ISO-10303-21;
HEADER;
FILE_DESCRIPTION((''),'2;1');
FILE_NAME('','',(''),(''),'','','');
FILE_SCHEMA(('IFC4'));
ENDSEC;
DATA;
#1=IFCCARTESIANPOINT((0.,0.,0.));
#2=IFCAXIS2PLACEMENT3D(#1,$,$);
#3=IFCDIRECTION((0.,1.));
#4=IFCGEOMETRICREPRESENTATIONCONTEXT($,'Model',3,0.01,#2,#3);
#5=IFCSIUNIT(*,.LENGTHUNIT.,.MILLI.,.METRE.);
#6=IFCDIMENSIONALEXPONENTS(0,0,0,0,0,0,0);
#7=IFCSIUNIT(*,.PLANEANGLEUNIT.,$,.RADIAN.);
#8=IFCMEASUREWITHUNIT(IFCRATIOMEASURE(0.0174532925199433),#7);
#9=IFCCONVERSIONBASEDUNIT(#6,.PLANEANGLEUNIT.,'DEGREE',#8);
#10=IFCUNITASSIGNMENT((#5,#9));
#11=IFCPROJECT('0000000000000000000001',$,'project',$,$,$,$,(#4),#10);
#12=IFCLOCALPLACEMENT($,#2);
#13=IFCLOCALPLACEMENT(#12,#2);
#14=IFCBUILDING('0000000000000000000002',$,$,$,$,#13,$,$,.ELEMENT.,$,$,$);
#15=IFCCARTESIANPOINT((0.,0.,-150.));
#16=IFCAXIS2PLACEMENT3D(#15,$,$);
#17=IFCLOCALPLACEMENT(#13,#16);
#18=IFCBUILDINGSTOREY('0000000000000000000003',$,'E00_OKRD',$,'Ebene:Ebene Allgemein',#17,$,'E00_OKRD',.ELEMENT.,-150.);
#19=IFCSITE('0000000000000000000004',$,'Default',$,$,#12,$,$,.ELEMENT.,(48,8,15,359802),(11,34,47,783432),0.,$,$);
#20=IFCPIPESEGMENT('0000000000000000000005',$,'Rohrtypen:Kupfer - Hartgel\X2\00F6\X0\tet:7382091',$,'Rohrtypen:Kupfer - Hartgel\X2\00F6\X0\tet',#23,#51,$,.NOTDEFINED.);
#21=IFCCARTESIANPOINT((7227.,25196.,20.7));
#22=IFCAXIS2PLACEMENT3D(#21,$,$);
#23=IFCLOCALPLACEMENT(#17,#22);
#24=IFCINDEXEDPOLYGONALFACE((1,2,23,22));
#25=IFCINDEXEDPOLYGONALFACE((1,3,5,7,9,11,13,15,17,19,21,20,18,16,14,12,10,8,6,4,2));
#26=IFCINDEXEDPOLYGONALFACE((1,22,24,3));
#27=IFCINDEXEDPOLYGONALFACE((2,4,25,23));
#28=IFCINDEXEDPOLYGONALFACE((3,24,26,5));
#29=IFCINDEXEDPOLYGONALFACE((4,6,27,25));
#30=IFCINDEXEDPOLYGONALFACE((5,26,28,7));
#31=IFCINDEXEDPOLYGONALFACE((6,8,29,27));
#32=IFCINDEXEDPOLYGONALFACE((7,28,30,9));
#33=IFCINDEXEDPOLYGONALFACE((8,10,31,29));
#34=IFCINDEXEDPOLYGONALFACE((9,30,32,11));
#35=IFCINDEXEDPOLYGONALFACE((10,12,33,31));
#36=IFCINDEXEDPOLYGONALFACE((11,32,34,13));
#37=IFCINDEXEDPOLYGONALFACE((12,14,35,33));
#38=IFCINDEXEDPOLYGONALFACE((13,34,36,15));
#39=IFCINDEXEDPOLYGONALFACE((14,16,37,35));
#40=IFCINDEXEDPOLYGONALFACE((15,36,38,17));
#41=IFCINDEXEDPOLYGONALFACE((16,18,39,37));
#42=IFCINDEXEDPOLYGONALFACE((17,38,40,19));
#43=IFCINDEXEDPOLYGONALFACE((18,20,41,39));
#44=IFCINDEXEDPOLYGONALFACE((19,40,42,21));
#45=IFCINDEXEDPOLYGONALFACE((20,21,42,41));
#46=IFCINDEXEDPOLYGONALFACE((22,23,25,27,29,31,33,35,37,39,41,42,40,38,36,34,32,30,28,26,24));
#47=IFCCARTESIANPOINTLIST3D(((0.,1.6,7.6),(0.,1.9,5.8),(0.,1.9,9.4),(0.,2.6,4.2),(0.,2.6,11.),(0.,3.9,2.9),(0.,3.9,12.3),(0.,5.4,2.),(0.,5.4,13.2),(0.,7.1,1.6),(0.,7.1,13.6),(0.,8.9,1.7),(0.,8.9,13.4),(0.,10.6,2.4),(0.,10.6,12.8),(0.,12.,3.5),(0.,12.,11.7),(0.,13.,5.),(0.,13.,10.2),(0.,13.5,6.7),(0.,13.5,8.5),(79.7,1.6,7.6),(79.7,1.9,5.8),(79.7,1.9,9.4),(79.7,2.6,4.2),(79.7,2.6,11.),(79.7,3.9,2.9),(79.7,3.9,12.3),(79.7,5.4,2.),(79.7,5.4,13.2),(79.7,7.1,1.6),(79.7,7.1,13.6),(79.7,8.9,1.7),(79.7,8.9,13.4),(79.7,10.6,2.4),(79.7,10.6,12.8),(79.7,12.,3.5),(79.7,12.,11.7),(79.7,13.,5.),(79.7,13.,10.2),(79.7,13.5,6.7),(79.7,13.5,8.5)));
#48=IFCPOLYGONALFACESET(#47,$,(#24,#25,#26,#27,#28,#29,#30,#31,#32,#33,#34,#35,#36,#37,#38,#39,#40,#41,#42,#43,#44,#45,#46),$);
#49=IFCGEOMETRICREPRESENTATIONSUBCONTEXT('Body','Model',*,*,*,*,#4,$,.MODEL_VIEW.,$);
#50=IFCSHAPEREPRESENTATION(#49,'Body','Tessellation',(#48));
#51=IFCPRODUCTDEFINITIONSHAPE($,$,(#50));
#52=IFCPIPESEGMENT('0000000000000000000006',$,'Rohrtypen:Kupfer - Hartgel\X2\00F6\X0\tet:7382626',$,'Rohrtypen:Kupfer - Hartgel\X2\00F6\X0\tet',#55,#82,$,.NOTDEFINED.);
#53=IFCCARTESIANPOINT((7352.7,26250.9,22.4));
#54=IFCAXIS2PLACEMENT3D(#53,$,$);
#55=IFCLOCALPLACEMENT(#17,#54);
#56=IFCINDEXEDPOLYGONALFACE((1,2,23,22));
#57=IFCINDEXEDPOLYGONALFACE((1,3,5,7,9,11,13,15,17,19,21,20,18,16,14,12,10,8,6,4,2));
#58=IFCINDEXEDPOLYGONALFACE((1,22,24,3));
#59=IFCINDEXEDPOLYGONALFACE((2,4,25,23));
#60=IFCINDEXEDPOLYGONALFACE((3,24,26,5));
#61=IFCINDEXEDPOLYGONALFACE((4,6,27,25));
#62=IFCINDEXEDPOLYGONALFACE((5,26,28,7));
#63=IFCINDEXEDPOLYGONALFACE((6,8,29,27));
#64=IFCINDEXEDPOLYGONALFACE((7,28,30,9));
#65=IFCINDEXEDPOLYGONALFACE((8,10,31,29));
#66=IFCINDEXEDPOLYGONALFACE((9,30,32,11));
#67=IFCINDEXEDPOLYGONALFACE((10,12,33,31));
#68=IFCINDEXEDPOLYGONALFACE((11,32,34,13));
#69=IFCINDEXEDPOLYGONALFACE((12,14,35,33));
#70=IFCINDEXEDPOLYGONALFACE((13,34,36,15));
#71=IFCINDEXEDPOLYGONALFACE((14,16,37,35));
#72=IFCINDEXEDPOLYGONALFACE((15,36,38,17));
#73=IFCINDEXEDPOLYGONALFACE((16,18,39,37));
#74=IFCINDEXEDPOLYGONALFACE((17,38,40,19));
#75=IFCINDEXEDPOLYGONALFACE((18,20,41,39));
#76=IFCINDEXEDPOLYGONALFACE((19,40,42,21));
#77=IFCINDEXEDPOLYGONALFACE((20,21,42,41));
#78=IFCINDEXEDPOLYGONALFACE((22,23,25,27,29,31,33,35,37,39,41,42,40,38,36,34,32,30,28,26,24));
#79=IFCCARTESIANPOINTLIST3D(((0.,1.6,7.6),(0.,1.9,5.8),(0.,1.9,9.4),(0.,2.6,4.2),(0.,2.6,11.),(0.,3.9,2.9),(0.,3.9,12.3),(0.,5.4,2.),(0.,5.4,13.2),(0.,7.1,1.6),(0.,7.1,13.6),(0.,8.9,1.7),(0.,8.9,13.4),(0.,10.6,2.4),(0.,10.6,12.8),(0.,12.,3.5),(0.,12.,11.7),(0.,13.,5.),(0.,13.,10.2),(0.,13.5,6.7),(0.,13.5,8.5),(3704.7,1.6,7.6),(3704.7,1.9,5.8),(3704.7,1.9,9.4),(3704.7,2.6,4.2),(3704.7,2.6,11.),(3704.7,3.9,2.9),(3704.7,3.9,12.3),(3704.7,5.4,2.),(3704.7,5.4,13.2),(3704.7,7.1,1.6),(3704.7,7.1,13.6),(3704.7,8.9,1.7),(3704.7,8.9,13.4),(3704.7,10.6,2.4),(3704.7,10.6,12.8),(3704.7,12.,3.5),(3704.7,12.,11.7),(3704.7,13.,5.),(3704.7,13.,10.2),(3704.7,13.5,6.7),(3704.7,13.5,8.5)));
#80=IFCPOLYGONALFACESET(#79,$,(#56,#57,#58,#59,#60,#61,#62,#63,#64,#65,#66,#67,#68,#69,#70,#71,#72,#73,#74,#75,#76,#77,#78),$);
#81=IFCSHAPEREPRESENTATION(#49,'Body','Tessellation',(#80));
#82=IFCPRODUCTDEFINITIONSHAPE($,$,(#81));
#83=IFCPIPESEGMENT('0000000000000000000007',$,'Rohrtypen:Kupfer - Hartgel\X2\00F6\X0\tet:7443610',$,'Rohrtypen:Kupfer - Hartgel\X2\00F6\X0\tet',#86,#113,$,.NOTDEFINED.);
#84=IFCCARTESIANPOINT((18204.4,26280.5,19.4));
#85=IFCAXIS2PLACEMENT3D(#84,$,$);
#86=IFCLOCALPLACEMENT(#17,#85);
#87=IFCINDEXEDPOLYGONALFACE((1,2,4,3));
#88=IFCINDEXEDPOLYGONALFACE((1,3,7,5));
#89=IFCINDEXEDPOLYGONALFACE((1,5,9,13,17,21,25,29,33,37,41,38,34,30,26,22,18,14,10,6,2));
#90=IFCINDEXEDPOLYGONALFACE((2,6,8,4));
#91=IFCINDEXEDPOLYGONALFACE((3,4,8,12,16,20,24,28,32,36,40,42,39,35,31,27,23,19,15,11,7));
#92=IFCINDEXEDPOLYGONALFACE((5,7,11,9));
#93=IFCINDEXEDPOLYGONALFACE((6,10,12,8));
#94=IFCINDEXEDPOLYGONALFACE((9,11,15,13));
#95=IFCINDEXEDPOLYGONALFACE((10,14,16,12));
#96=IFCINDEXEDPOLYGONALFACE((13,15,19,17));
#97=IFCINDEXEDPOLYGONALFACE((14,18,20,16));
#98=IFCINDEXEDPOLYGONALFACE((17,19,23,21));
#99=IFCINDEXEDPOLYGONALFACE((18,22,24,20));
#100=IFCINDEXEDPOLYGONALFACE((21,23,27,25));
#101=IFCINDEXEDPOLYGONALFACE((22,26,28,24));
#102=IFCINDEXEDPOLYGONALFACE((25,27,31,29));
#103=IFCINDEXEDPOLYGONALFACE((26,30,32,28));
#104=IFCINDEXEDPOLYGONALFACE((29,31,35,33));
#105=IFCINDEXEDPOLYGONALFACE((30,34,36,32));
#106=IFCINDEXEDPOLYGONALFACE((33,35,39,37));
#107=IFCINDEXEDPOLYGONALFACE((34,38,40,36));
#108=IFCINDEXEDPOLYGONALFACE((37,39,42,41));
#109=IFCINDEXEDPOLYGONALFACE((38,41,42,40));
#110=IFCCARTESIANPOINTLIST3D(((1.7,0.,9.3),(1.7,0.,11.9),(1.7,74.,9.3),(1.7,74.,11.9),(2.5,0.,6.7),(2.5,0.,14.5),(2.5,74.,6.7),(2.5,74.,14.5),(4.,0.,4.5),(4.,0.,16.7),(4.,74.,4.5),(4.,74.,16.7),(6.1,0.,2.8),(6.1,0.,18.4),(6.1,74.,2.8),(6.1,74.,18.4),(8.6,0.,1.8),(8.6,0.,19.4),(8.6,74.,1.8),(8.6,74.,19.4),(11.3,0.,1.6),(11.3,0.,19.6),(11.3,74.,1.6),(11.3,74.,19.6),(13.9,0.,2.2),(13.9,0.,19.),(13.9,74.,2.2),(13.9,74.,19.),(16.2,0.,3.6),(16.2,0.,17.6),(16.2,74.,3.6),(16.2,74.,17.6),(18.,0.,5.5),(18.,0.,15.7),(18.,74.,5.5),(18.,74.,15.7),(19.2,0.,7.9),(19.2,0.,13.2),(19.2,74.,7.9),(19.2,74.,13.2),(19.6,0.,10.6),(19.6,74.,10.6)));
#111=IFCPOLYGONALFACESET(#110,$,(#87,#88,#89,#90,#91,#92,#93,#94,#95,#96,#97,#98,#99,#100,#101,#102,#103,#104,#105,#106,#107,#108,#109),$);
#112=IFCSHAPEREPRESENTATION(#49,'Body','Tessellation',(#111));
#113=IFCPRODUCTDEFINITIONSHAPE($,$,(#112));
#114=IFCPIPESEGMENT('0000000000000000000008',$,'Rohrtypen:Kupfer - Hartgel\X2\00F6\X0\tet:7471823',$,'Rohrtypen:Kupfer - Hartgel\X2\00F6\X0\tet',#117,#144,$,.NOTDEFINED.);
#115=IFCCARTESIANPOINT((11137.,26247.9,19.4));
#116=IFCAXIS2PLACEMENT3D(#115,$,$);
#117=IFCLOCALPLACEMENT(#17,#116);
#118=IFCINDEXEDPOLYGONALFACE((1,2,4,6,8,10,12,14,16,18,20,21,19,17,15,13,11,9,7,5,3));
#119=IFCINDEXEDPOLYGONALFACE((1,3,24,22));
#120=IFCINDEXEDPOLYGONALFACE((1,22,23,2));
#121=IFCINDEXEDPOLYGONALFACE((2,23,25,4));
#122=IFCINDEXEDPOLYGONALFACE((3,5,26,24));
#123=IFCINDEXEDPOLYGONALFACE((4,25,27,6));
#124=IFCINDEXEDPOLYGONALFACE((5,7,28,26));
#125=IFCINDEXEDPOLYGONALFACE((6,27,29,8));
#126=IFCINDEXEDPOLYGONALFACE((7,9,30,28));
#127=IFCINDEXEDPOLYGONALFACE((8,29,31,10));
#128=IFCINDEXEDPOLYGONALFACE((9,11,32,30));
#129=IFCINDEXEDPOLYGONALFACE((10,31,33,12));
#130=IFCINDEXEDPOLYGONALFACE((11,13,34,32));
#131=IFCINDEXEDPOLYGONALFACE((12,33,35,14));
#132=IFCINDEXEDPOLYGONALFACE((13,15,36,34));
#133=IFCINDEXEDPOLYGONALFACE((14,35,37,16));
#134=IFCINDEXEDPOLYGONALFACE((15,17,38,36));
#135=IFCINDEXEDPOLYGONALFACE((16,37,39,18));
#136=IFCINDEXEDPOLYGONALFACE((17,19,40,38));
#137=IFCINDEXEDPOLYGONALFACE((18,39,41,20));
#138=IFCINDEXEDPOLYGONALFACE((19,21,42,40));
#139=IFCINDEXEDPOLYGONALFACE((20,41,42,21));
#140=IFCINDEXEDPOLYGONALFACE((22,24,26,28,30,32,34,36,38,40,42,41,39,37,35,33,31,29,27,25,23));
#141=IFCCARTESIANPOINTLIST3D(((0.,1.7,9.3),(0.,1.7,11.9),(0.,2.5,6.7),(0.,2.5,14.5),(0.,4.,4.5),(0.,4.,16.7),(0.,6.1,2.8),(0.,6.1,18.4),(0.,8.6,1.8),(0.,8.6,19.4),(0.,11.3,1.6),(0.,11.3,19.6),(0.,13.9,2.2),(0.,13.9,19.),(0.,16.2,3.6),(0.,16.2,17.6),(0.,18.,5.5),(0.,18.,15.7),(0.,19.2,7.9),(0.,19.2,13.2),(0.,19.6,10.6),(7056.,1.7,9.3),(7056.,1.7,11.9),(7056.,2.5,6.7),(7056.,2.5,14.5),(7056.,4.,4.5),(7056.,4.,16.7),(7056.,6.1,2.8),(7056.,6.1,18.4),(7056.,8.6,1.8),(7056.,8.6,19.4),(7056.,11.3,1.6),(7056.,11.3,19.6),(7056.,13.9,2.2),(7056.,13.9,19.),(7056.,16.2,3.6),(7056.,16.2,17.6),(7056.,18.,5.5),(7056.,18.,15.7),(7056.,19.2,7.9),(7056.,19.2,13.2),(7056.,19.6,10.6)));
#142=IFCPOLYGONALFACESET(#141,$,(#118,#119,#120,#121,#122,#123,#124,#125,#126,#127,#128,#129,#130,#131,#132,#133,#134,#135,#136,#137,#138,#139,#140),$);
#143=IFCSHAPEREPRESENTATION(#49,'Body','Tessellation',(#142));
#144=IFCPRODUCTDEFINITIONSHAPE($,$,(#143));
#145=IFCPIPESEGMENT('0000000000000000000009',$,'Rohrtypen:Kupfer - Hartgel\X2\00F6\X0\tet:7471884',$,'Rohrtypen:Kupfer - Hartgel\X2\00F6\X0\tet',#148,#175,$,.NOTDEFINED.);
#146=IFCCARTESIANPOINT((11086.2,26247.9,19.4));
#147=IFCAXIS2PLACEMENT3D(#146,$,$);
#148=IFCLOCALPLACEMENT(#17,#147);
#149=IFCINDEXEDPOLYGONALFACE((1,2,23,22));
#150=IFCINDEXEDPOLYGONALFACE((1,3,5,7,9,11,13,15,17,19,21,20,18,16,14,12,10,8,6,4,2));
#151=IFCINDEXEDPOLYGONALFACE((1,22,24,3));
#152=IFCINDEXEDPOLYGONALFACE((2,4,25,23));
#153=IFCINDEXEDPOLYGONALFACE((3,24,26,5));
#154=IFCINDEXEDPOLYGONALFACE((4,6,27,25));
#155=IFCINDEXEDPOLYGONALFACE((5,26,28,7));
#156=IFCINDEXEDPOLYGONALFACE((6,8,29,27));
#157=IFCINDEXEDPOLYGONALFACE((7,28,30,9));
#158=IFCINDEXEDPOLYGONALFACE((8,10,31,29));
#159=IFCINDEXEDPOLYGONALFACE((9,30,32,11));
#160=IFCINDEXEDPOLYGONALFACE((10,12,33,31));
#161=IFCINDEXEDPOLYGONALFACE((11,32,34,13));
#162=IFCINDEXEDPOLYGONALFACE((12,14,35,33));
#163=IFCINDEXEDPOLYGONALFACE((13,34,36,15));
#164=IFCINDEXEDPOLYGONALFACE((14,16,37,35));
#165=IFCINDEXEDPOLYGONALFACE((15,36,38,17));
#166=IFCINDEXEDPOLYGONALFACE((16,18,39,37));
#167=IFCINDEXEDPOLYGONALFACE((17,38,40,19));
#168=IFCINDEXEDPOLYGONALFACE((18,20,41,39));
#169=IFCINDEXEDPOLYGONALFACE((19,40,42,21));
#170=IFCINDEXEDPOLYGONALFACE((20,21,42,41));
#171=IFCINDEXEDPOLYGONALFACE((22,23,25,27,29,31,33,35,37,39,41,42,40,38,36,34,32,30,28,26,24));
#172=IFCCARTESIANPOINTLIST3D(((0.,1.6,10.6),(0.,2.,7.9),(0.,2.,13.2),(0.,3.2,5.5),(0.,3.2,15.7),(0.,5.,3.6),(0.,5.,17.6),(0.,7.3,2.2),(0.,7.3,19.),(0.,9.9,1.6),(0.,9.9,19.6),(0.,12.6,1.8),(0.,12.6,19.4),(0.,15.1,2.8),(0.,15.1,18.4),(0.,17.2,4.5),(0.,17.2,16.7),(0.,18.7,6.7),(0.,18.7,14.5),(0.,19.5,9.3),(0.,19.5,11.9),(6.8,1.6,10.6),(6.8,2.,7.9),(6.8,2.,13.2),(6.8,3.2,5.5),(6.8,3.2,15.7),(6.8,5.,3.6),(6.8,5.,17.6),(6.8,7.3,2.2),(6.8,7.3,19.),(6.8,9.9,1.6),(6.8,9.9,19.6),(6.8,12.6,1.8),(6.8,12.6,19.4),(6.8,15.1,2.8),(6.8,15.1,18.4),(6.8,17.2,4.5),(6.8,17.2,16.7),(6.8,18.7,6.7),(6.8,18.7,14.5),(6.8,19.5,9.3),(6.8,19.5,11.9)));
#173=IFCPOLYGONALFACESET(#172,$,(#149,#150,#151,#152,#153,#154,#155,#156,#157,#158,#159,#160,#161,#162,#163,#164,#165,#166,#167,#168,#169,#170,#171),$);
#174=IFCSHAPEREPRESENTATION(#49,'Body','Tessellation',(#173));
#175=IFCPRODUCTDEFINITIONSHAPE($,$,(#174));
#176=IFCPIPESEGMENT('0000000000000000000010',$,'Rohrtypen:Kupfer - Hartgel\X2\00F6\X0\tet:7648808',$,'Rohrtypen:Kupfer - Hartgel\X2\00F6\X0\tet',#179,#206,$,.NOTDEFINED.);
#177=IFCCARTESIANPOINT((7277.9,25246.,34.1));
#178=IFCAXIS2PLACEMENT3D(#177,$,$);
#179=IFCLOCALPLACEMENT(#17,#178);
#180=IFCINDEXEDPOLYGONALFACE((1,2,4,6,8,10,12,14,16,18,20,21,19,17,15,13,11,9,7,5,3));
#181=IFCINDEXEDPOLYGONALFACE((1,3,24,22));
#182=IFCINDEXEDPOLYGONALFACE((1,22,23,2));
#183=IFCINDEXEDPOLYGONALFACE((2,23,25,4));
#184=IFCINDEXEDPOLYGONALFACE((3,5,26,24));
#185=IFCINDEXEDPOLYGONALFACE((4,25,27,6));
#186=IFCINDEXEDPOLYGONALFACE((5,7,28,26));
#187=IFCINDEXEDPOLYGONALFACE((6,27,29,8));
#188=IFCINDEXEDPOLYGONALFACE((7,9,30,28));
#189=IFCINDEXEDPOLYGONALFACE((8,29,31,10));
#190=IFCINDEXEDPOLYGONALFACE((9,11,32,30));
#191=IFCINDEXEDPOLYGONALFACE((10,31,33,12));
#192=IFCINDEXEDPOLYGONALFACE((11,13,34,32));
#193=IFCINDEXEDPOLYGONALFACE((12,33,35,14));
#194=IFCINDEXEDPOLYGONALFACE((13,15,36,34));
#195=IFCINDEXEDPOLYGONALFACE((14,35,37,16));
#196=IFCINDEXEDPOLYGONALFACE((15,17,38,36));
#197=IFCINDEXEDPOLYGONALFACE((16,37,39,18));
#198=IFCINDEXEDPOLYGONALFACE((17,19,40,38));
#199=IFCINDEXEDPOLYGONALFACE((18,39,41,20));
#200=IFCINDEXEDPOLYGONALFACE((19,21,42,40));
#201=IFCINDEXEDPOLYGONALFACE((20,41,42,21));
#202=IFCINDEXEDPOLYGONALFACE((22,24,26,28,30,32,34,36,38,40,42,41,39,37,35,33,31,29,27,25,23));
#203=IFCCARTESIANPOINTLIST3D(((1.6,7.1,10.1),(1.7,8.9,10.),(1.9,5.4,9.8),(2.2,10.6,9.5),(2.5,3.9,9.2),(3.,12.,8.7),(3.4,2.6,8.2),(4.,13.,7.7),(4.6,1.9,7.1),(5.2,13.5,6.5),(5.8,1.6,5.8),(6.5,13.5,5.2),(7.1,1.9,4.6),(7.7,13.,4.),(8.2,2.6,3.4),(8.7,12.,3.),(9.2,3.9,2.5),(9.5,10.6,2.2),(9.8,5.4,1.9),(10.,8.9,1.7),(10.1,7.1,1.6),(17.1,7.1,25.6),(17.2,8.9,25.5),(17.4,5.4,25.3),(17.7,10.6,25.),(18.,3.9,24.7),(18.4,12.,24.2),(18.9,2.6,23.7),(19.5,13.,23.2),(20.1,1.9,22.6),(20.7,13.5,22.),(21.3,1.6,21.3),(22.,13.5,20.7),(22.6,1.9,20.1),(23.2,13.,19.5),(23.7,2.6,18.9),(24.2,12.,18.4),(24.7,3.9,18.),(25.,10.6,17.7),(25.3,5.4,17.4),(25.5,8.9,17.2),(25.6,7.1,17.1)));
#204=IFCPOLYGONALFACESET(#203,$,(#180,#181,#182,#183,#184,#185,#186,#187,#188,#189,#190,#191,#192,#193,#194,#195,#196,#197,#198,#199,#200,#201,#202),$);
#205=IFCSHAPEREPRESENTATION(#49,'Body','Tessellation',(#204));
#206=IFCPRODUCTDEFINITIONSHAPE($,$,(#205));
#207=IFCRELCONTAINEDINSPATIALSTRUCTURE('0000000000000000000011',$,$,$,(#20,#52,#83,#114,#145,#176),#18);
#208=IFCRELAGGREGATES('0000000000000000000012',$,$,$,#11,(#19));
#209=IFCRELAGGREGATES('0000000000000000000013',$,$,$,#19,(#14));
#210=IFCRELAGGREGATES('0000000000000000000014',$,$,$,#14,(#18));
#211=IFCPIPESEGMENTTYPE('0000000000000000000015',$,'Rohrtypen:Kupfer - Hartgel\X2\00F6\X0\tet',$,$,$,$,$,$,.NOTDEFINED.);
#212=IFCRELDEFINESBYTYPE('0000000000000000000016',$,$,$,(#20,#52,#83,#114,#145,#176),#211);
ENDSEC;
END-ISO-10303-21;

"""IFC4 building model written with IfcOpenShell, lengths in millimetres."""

from ifc_helpers import new_model, entity, si_unit, converted_unit, direction, frame, frame_2d, origin, origin_2d_with_axis, place, context, subcontext, project, spatial, circle, extrude, type_object, element, save


model = new_model("IFC4")

# Units and contexts
model_context = context("Model", 3, precision=0.01, world=origin(), true_north=direction((0.0, 1.0)))
body_context = subcontext(model_context, "Body", "Model", "MODEL_VIEW")
ifc_project = project(units=[si_unit("LENGTHUNIT", "METRE", prefix="MILLI"), converted_unit("PLANEANGLEUNIT", "DEGREE", entity("IfcRatioMeasure", 0.0174532925199433), si_unit("PLANEANGLEUNIT", "RADIAN"), dimensions=[0, 0, 0, 0, 0, 0, 0])], contexts=[model_context])

# Site, building, storey
site_placement = place(None, origin())
site = spatial("IfcSite", under=ifc_project, at=site_placement, Name="Default", CompositionType="ELEMENT", RefLatitude=(48, 8, 15, 359802), RefLongitude=(11, 34, 47, 783432), RefElevation=0.0)
building_placement = place(site_placement, origin())
building = spatial("IfcBuilding", under=site, at=building_placement, CompositionType="ELEMENT")
storey_placement = place(building_placement, frame((0.0, 0.0, -150.0)))
storey = spatial("IfcBuildingStorey", under=building, at=storey_placement, Name="E00_OKRD", ObjectType="Ebene:Ebene Allgemein", LongName="E00_OKRD", CompositionType="ELEMENT", Elevation=-150.0)

# Pipe segments
pipe_segment_type = type_object("IfcPipeSegmentType", Name="Rohrtypen:Kupfer - Hartgelötet", PredefinedType="NOTDEFINED")
pipe_segment_1_placement = place(storey_placement, frame((7227.0, 25196.0, 20.7)))
element("IfcPipeSegment", 1, at=pipe_segment_1_placement, inside=storey, type_object=pipe_segment_type, Name="Rohrtypen:Kupfer - Hartgelötet:7382091", ObjectType="Rohrtypen:Kupfer - Hartgelötet", PredefinedType="NOTDEFINED", context=body_context, shape_type="SweptSolid", body=[
    extrude(circle(Radius=6.0, at=frame_2d((0.0, 0.0), x_axis=(1.0, 0.0))), frame((0.0, 7.6, 7.6), z_axis=(1.0, 0.0, 0.0), x_axis=(0.0, -1.0, 0.0)), (0.0, 0.0, 1.0), 79.7),
])
pipe_segment_2_placement = place(storey_placement, frame((7352.7, 26250.9, 22.4)))
element("IfcPipeSegment", 2, at=pipe_segment_2_placement, inside=storey, type_object=pipe_segment_type, Name="Rohrtypen:Kupfer - Hartgelötet:7382626", ObjectType="Rohrtypen:Kupfer - Hartgelötet", PredefinedType="NOTDEFINED", context=body_context, shape_type="SweptSolid", body=[
    extrude(circle(Radius=6.0, at=frame_2d((0.0, 0.0), x_axis=(1.0, 0.0))), frame((0.0, 7.6, 7.6), z_axis=(1.0, 0.0, 0.0), x_axis=(0.0, -1.0, 0.0)), (0.0, 0.0, 1.0), 3704.7),
])
pipe_segment_3_placement = place(storey_placement, frame((18204.4, 26280.5, 19.4)))
element("IfcPipeSegment", 3, at=pipe_segment_3_placement, inside=storey, type_object=pipe_segment_type, Name="Rohrtypen:Kupfer - Hartgelötet:7443610", ObjectType="Rohrtypen:Kupfer - Hartgelötet", PredefinedType="NOTDEFINED", context=body_context, shape_type="SweptSolid", body=[
    extrude(circle(Radius=9.0, at=origin_2d_with_axis()), frame((10.6, 0.0, 10.6), z_axis=(0.0, 1.0, 0.0), x_axis=(1.0, 0.0, 0.0)), (0.0, 0.0, 1.0), 74.0),
])
pipe_segment_4_placement = place(storey_placement, frame((11137.0, 26247.9, 19.4)))
element("IfcPipeSegment", 4, at=pipe_segment_4_placement, inside=storey, type_object=pipe_segment_type, Name="Rohrtypen:Kupfer - Hartgelötet:7471823", ObjectType="Rohrtypen:Kupfer - Hartgelötet", PredefinedType="NOTDEFINED", context=body_context, shape_type="SweptSolid", body=[
    extrude(circle(Radius=9.0, at=origin_2d_with_axis()), frame((0.0, 10.6, 10.6), z_axis=(1.0, 0.0, 0.0), x_axis=(0.0, 1.0, 0.0)), (0.0, 0.0, 1.0), 7056.0),
])
pipe_segment_5_placement = place(storey_placement, frame((11086.2, 26247.9, 19.4)))
element("IfcPipeSegment", 5, at=pipe_segment_5_placement, inside=storey, type_object=pipe_segment_type, Name="Rohrtypen:Kupfer - Hartgelötet:7471884", ObjectType="Rohrtypen:Kupfer - Hartgelötet", PredefinedType="NOTDEFINED", context=body_context, shape_type="SweptSolid", body=[
    extrude(circle(Radius=9.0, at=frame_2d((0.0, 0.0), x_axis=(1.0, 0.0))), frame((0.0, 10.6, 10.6), z_axis=(1.0, 0.0, 0.0), x_axis=(0.0, -1.0, 0.0)), (0.0, 0.0, 1.0), 6.8),
])
pipe_segment_6_placement = place(storey_placement, frame((7277.9, 25246.0, 34.1)))
element("IfcPipeSegment", 6, at=pipe_segment_6_placement, inside=storey, type_object=pipe_segment_type, Name="Rohrtypen:Kupfer - Hartgelötet:7648808", ObjectType="Rohrtypen:Kupfer - Hartgelötet", PredefinedType="NOTDEFINED", context=body_context, shape_type="SweptSolid", body=[
    extrude(circle(Radius=6.0, at=origin_2d_with_axis()), frame((5.8, 7.6, 5.8), z_axis=(0.707107, 0.0, 0.707107), x_axis=(0.0, -1.0, 0.0)), (0.0, 0.0, 1.0), 21.9),
])

save(model, "model.ifc")
